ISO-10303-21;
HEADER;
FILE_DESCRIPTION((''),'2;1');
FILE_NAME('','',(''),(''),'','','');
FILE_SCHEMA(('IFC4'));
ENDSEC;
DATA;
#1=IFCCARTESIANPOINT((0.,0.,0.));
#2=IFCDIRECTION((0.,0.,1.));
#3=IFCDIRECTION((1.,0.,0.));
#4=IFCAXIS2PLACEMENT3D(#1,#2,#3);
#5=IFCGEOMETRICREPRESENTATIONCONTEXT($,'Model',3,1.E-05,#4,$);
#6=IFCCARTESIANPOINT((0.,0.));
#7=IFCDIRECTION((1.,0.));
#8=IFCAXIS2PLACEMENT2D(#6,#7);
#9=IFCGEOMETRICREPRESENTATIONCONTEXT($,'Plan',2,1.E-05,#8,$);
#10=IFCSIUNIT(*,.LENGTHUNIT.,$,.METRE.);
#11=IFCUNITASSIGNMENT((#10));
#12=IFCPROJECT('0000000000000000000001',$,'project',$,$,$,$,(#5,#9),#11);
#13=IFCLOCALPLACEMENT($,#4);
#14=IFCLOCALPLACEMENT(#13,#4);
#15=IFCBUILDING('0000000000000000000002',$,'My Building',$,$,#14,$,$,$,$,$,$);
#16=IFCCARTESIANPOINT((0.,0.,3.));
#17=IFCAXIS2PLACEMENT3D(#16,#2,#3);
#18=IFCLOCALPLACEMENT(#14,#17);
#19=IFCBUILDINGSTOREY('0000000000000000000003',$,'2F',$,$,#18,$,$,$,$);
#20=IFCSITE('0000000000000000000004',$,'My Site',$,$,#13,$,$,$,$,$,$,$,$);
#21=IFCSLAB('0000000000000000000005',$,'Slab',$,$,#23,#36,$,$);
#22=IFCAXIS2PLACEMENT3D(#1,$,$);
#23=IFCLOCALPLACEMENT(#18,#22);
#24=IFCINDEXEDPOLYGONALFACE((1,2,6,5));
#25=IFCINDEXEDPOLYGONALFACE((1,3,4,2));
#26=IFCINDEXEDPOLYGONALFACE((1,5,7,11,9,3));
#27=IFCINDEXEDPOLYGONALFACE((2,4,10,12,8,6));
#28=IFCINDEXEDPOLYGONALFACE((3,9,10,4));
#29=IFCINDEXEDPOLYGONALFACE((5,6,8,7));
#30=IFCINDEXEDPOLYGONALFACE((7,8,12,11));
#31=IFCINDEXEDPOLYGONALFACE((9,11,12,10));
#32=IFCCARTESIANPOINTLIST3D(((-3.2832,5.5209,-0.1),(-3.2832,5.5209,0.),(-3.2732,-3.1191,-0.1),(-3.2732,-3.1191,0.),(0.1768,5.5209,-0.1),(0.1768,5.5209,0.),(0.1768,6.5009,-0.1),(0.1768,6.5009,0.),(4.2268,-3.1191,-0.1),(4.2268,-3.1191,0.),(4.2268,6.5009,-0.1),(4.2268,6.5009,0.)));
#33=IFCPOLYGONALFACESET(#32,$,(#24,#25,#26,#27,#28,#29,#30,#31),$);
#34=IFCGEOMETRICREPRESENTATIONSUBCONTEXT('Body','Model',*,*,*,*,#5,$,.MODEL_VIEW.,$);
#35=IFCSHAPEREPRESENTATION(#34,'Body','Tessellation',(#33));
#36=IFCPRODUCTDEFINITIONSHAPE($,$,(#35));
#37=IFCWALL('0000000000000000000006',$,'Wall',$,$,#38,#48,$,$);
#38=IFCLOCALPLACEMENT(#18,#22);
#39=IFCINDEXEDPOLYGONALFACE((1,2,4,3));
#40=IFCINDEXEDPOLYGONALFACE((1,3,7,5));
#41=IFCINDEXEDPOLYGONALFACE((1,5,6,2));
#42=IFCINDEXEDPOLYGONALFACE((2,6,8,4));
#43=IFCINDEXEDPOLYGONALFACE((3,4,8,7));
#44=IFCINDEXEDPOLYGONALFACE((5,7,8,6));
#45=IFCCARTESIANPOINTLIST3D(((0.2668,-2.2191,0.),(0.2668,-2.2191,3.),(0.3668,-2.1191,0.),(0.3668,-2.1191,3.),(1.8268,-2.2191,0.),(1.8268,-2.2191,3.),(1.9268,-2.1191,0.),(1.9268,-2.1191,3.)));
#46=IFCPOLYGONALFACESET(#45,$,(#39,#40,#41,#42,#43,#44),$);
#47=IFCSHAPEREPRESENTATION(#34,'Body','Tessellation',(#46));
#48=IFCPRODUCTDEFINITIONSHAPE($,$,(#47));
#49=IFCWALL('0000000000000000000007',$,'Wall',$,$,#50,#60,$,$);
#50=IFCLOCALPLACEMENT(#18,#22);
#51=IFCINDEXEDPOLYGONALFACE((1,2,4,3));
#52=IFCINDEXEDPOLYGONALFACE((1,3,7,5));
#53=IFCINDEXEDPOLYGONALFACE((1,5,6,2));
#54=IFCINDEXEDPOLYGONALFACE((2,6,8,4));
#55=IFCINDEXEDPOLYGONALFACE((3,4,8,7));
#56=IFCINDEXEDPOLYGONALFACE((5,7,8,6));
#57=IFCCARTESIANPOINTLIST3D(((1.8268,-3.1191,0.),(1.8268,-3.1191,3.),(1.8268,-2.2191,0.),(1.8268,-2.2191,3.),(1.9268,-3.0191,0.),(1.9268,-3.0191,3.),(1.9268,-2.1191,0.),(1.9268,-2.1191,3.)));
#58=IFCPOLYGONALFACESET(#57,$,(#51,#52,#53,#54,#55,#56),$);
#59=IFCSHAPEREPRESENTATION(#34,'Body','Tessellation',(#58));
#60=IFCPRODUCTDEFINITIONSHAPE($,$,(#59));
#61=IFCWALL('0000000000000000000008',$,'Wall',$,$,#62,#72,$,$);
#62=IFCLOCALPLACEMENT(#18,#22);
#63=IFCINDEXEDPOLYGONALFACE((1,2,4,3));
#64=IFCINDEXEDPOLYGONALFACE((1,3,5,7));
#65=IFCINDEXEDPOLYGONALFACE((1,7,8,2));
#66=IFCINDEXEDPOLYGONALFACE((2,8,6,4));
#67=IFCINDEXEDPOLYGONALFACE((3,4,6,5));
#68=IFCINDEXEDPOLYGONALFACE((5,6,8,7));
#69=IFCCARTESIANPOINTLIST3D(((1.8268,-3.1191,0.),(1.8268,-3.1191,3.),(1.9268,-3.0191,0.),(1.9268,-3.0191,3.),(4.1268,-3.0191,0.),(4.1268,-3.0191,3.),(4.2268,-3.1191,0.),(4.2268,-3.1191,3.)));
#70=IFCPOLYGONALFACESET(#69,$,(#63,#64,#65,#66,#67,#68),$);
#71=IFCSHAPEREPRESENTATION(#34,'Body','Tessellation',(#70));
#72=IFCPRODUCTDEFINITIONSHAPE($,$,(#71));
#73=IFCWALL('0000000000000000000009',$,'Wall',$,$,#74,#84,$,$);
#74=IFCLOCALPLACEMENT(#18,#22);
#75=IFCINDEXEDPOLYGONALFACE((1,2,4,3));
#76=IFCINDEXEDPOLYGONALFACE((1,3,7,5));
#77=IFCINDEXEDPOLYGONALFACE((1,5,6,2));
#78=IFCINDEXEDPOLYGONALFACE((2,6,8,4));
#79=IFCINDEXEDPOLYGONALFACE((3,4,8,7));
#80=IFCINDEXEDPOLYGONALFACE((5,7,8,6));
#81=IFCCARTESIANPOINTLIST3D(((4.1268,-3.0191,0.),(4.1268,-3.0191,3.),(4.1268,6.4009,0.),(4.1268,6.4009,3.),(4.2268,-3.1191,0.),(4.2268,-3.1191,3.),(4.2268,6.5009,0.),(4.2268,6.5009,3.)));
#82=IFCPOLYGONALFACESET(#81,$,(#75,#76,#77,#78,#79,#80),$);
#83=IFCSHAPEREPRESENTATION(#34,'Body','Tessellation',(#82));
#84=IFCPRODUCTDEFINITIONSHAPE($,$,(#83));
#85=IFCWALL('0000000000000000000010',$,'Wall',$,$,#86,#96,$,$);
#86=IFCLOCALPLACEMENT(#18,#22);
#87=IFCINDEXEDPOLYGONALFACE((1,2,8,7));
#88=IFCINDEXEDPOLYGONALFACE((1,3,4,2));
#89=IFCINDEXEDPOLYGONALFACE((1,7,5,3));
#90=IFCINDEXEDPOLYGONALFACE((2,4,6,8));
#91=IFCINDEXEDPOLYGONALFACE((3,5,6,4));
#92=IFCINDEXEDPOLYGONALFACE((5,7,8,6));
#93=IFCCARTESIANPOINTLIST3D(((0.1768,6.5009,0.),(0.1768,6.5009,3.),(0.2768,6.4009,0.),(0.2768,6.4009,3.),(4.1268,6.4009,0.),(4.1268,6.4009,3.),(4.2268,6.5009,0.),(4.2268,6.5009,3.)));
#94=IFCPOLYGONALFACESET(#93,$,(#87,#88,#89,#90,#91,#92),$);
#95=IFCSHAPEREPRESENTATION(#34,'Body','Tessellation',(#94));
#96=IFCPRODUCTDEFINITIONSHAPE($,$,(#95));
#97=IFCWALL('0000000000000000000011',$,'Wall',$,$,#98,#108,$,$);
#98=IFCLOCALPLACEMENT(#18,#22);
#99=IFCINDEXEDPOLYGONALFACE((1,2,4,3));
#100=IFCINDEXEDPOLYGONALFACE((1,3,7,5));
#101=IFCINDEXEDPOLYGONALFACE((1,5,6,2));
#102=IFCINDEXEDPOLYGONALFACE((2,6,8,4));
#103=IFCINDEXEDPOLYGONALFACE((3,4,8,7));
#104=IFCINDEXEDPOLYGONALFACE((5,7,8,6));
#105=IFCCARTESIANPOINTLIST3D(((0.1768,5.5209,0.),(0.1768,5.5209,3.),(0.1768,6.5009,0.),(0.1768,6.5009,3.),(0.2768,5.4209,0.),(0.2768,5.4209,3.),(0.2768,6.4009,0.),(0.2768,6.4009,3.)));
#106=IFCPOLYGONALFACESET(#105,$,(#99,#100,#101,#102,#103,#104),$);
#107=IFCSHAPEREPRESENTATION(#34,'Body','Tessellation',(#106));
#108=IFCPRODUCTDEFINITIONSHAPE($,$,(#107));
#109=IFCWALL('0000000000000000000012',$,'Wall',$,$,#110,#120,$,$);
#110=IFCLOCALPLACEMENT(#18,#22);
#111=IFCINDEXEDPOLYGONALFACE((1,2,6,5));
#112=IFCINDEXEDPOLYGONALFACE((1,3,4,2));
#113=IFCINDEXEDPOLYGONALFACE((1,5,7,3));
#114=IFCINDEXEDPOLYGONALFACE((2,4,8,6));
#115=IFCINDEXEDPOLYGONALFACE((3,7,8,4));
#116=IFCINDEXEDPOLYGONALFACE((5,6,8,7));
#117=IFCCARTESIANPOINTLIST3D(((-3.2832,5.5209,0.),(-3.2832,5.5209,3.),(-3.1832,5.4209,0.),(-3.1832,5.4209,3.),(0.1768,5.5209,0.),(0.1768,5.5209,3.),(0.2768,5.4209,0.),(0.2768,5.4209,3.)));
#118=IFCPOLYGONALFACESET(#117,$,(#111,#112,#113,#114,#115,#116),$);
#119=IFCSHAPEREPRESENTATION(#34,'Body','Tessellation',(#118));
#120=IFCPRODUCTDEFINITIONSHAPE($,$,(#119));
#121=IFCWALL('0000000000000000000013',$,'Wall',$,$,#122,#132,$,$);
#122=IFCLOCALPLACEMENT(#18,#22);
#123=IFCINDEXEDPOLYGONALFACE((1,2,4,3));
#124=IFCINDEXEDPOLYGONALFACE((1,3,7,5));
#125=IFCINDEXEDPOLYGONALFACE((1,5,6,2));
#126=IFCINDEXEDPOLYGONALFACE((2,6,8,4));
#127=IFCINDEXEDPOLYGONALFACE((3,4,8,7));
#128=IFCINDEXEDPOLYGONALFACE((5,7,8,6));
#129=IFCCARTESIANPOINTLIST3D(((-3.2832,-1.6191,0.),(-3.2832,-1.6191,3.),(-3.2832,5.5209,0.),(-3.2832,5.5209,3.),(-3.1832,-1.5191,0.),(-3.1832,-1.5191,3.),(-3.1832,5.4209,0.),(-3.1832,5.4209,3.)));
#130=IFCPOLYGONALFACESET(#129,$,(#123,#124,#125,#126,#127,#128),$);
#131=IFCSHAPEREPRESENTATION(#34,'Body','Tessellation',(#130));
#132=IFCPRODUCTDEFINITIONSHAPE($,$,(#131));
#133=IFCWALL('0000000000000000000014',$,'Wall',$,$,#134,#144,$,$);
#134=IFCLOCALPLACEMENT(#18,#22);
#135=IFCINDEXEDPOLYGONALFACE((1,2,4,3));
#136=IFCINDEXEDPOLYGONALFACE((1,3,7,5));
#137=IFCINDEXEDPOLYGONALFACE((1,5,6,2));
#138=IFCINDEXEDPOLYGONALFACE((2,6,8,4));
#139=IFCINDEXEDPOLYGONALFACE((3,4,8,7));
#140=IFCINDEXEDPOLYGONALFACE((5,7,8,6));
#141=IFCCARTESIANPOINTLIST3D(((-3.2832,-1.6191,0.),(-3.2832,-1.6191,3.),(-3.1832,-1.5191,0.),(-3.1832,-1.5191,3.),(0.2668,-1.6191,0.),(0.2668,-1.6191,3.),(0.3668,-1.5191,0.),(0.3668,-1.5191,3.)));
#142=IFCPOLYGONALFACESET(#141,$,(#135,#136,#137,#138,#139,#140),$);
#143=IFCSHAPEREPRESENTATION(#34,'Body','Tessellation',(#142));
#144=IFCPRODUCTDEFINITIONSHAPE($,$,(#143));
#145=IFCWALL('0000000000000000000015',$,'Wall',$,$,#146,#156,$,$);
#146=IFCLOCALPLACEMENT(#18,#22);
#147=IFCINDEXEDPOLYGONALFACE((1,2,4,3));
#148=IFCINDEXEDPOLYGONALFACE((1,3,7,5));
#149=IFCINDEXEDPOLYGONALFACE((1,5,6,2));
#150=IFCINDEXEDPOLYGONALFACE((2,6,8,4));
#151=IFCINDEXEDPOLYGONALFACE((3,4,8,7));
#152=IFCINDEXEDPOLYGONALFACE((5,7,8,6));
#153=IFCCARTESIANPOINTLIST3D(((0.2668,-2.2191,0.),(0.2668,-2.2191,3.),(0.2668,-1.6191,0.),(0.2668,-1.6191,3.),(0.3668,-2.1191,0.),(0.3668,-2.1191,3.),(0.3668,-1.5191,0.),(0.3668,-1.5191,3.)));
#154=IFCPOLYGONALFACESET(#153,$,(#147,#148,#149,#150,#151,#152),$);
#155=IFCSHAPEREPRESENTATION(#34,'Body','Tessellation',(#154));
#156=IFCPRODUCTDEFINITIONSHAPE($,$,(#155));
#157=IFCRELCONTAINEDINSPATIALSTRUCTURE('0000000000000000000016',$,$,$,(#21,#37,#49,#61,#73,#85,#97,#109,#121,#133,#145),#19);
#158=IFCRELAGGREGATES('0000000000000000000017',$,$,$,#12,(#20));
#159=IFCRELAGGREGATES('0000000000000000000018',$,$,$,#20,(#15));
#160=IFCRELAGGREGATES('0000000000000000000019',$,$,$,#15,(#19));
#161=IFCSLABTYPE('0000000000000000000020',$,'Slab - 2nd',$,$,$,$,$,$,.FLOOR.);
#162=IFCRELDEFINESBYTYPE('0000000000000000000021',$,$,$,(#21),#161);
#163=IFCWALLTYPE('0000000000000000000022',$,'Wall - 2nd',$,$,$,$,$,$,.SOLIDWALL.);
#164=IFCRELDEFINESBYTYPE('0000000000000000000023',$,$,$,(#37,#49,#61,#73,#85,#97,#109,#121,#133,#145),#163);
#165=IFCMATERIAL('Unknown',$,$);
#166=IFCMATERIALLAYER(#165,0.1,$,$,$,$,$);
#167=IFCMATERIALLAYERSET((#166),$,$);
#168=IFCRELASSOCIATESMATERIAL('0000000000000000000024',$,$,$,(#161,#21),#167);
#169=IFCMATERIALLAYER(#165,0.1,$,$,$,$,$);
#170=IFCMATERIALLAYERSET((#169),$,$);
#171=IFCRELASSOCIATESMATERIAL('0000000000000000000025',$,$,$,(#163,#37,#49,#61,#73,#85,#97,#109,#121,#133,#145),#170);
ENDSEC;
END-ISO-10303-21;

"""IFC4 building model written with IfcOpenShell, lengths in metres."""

from ifc_helpers import new_model, si_unit, frame, origin_with_axes, origin_2d_with_axis, place, context, subcontext, project, spatial, line, indexed_curve, outline, extrude, material, layer, layer_set, layer_usage, type_object, element, save


model = new_model("IFC4")

# Units and contexts
model_context = context("Model", 3, precision=1e-05, world=origin_with_axes())
plan_context = context("Plan", 2, precision=1e-05, world=origin_2d_with_axis())
body_context_1 = subcontext(model_context, "Body", "Model", "MODEL_VIEW")
ifc_project = project(units=[si_unit("LENGTHUNIT", "METRE")], contexts=[model_context, plan_context])

# Site, building, storey
site_placement = place(None, origin_with_axes())
site = spatial("IfcSite", under=ifc_project, at=site_placement, Name="My Site")
building_placement = place(site_placement, origin_with_axes())
building = spatial("IfcBuilding", under=site, at=building_placement, Name="My Building")
storey_placement = place(building_placement, frame((0.0, 0.0, 3.0), z_axis=(0.0, 0.0, 1.0), x_axis=(1.0, 0.0, 0.0)))
storey = spatial("IfcBuildingStorey", under=building, at=storey_placement, Name="2F")

# Slab
ifc_material = material(Name="Unknown")
ifc_layer_1 = layer(ifc_material, 0.1)
ifc_layer_set_1 = layer_set([ifc_layer_1])
ifc_layer_usage_1 = layer_usage(ifc_layer_set_1, "AXIS3", "POSITIVE", -0.1)
slab_type = type_object("IfcSlabType", Name="Slab - 2nd", PredefinedType="FLOOR", material=ifc_layer_set_1)
slab_placement = place(storey_placement, frame((4.2268, -3.1191, 0.0), z_axis=(0.0, 0.0, 1.0), x_axis=(1.0, 0.0, 0.0)))
element("IfcSlab", 1, at=slab_placement, inside=storey, type_object=slab_type, material=ifc_layer_usage_1, Name="Slab", context=body_context_1, shape_type="SweptSolid", body=[
    extrude(outline(indexed_curve([(0.0, 0.0), (-7.5, 0.0), (-7.51, 8.64), (-4.05, 8.64), (-4.05, 9.62), (0.0, 9.62), (0.0, 0.0)])), frame((0.0, 0.0, -0.1), z_axis=(0.0, 0.0, 1.0), x_axis=(1.0, 0.0, 0.0)), (0.0, 0.0, 1.0), 0.1),
])

# Walls
ifc_layer_2 = layer(ifc_material, 0.1)
ifc_layer_set_2 = layer_set([ifc_layer_2])
ifc_layer_usage_2 = layer_usage(ifc_layer_set_2, "AXIS2", "POSITIVE", 0.0)
wall_type = type_object("IfcWallType", Name="Wall - 2nd", PredefinedType="SOLIDWALL", material=ifc_layer_set_2)
wall_1_placement = place(storey_placement, frame((0.2668, -2.2191, 0.0), z_axis=(0.0, 0.0, 1.0), x_axis=(1.0, 0.0, 0.0)))
element("IfcWall", 2, at=wall_1_placement, inside=storey, type_object=wall_type, material=ifc_layer_usage_2, Name="Wall", context=body_context_1, shape_type="SweptSolid", body=[
    extrude(outline(indexed_curve([(0.0, 0.0), (0.1, 0.1), (1.66, 0.1), (1.56, 0.0)], segments=[line(1, 2, 3, 4, 1)])), origin_with_axes(), (0.0, 0.0, 1.0), 3.0),
])
ifc_layer_usage_3 = layer_usage(ifc_layer_set_2, "AXIS2", "POSITIVE", 0.0)
wall_2_placement = place(storey_placement, frame((1.8268, -2.2191, 0.0), z_axis=(0.0, 0.0, 1.0), x_axis=(0.0, -1.0, 0.0)))
element("IfcWall", 3, at=wall_2_placement, inside=storey, type_object=wall_type, material=ifc_layer_usage_3, Name="Wall", context=body_context_1, shape_type="SweptSolid", body=[
    extrude(outline(indexed_curve([(0.0, 0.0), (-0.1, 0.1), (0.8, 0.1), (0.9, 0.0)], segments=[line(1, 2, 3, 4, 1)])), origin_with_axes(), (0.0, 0.0, 1.0), 3.0),
])
ifc_layer_usage_4 = layer_usage(ifc_layer_set_2, "AXIS2", "POSITIVE", 0.0)
wall_3_placement = place(storey_placement, frame((1.8268, -3.1191, 0.0), z_axis=(0.0, 0.0, 1.0), x_axis=(1.0, 0.0, 0.0)))
element("IfcWall", 4, at=wall_3_placement, inside=storey, type_object=wall_type, material=ifc_layer_usage_4, Name="Wall", context=body_context_1, shape_type="SweptSolid", body=[
    extrude(outline(indexed_curve([(0.0, 0.0), (0.1, 0.1), (2.3, 0.1), (2.4, 0.0)], segments=[line(1, 2, 3, 4, 1)])), origin_with_axes(), (0.0, 0.0, 1.0), 3.0),
])
ifc_layer_usage_5 = layer_usage(ifc_layer_set_2, "AXIS2", "POSITIVE", 0.0)
wall_4_placement = place(storey_placement, frame((4.2268, -3.1191, 0.0), z_axis=(0.0, 0.0, 1.0), x_axis=(0.0, 1.0, 0.0)))
element("IfcWall", 5, at=wall_4_placement, inside=storey, type_object=wall_type, material=ifc_layer_usage_5, Name="Wall", context=body_context_1, shape_type="SweptSolid", body=[
    extrude(outline(indexed_curve([(0.0, 0.0), (0.1, 0.1), (9.52, 0.1), (9.62, 0.0)], segments=[line(1, 2, 3, 4, 1)])), origin_with_axes(), (0.0, 0.0, 1.0), 3.0),
])
ifc_layer_usage_6 = layer_usage(ifc_layer_set_2, "AXIS2", "POSITIVE", 0.0)
wall_5_placement = place(storey_placement, frame((4.2268, 6.5009, 0.0), z_axis=(0.0, 0.0, 1.0), x_axis=(-1.0, 0.0, 0.0)))
element("IfcWall", 6, at=wall_5_placement, inside=storey, type_object=wall_type, material=ifc_layer_usage_6, Name="Wall", context=body_context_1, shape_type="SweptSolid", body=[
    extrude(outline(indexed_curve([(0.0, 0.0), (0.1, 0.1), (3.95, 0.1), (4.05, 0.0)], segments=[line(1, 2, 3, 4, 1)])), origin_with_axes(), (0.0, 0.0, 1.0), 3.0),
])
ifc_layer_usage_7 = layer_usage(ifc_layer_set_2, "AXIS2", "POSITIVE", 0.0)
wall_6_placement = place(storey_placement, frame((0.1768, 6.5009, 0.0), z_axis=(0.0, 0.0, 1.0), x_axis=(0.0, -1.0, 0.0)))
element("IfcWall", 7, at=wall_6_placement, inside=storey, type_object=wall_type, material=ifc_layer_usage_7, Name="Wall", context=body_context_1, shape_type="SweptSolid", body=[
    extrude(outline(indexed_curve([(0.0, 0.0), (0.1, 0.1), (1.08, 0.1), (0.98, 0.0)], segments=[line(1, 2, 3, 4, 1)])), origin_with_axes(), (0.0, 0.0, 1.0), 3.0),
])
ifc_layer_usage_8 = layer_usage(ifc_layer_set_2, "AXIS2", "POSITIVE", 0.0)
wall_7_placement = place(storey_placement, frame((0.1768, 5.5209, 0.0), z_axis=(0.0, 0.0, 1.0), x_axis=(-1.0, 0.0, 0.0)))
element("IfcWall", 8, at=wall_7_placement, inside=storey, type_object=wall_type, material=ifc_layer_usage_8, Name="Wall", context=body_context_1, shape_type="SweptSolid", body=[
    extrude(outline(indexed_curve([(0.0, 0.0), (-0.1, 0.1), (3.36, 0.1), (3.46, 0.0)], segments=[line(1, 2, 3, 4, 1)])), origin_with_axes(), (0.0, 0.0, 1.0), 3.0),
])
ifc_layer_usage_9 = layer_usage(ifc_layer_set_2, "AXIS2", "POSITIVE", 0.0)
wall_8_placement = place(storey_placement, frame((-3.2832, 5.5209, 0.0), z_axis=(0.0, 0.0, 1.0), x_axis=(0.0, -1.0, 0.0)))
element("IfcWall", 9, at=wall_8_placement, inside=storey, type_object=wall_type, material=ifc_layer_usage_9, Name="Wall", context=body_context_1, shape_type="SweptSolid", body=[
    extrude(outline(indexed_curve([(0.0, 0.0), (0.1, 0.1), (7.04, 0.1), (7.14, 0.0)], segments=[line(1, 2, 3, 4, 1)])), origin_with_axes(), (0.0, 0.0, 1.0), 3.0),
])
ifc_layer_usage_10 = layer_usage(ifc_layer_set_2, "AXIS2", "POSITIVE", 0.0)
wall_9_placement = place(storey_placement, frame((-3.2832, -1.6191, 0.0), z_axis=(0.0, 0.0, 1.0), x_axis=(1.0, 0.0, 0.0)))
element("IfcWall", 10, at=wall_9_placement, inside=storey, type_object=wall_type, material=ifc_layer_usage_10, Name="Wall", context=body_context_1, shape_type="SweptSolid", body=[
    extrude(outline(indexed_curve([(0.0, 0.0), (0.1, 0.1), (3.65, 0.1), (3.55, 0.0)], segments=[line(1, 2, 3, 4, 1)])), origin_with_axes(), (0.0, 0.0, 1.0), 3.0),
])
ifc_layer_usage_11 = layer_usage(ifc_layer_set_2, "AXIS2", "POSITIVE", 0.0)
wall_10_placement = place(storey_placement, frame((0.2668, -1.6191, 0.0), z_axis=(0.0, 0.0, 1.0), x_axis=(0.0, -1.0, 0.0)))
element("IfcWall", 11, at=wall_10_placement, inside=storey, type_object=wall_type, material=ifc_layer_usage_11, Name="Wall", context=body_context_1, shape_type="SweptSolid", body=[
    extrude(outline(indexed_curve([(0.0, 0.0), (-0.1, 0.1), (0.5, 0.1), (0.6, 0.0)], segments=[line(1, 2, 3, 4, 1)])), origin_with_axes(), (0.0, 0.0, 1.0), 3.0),
])

save(model, "model.ifc")
